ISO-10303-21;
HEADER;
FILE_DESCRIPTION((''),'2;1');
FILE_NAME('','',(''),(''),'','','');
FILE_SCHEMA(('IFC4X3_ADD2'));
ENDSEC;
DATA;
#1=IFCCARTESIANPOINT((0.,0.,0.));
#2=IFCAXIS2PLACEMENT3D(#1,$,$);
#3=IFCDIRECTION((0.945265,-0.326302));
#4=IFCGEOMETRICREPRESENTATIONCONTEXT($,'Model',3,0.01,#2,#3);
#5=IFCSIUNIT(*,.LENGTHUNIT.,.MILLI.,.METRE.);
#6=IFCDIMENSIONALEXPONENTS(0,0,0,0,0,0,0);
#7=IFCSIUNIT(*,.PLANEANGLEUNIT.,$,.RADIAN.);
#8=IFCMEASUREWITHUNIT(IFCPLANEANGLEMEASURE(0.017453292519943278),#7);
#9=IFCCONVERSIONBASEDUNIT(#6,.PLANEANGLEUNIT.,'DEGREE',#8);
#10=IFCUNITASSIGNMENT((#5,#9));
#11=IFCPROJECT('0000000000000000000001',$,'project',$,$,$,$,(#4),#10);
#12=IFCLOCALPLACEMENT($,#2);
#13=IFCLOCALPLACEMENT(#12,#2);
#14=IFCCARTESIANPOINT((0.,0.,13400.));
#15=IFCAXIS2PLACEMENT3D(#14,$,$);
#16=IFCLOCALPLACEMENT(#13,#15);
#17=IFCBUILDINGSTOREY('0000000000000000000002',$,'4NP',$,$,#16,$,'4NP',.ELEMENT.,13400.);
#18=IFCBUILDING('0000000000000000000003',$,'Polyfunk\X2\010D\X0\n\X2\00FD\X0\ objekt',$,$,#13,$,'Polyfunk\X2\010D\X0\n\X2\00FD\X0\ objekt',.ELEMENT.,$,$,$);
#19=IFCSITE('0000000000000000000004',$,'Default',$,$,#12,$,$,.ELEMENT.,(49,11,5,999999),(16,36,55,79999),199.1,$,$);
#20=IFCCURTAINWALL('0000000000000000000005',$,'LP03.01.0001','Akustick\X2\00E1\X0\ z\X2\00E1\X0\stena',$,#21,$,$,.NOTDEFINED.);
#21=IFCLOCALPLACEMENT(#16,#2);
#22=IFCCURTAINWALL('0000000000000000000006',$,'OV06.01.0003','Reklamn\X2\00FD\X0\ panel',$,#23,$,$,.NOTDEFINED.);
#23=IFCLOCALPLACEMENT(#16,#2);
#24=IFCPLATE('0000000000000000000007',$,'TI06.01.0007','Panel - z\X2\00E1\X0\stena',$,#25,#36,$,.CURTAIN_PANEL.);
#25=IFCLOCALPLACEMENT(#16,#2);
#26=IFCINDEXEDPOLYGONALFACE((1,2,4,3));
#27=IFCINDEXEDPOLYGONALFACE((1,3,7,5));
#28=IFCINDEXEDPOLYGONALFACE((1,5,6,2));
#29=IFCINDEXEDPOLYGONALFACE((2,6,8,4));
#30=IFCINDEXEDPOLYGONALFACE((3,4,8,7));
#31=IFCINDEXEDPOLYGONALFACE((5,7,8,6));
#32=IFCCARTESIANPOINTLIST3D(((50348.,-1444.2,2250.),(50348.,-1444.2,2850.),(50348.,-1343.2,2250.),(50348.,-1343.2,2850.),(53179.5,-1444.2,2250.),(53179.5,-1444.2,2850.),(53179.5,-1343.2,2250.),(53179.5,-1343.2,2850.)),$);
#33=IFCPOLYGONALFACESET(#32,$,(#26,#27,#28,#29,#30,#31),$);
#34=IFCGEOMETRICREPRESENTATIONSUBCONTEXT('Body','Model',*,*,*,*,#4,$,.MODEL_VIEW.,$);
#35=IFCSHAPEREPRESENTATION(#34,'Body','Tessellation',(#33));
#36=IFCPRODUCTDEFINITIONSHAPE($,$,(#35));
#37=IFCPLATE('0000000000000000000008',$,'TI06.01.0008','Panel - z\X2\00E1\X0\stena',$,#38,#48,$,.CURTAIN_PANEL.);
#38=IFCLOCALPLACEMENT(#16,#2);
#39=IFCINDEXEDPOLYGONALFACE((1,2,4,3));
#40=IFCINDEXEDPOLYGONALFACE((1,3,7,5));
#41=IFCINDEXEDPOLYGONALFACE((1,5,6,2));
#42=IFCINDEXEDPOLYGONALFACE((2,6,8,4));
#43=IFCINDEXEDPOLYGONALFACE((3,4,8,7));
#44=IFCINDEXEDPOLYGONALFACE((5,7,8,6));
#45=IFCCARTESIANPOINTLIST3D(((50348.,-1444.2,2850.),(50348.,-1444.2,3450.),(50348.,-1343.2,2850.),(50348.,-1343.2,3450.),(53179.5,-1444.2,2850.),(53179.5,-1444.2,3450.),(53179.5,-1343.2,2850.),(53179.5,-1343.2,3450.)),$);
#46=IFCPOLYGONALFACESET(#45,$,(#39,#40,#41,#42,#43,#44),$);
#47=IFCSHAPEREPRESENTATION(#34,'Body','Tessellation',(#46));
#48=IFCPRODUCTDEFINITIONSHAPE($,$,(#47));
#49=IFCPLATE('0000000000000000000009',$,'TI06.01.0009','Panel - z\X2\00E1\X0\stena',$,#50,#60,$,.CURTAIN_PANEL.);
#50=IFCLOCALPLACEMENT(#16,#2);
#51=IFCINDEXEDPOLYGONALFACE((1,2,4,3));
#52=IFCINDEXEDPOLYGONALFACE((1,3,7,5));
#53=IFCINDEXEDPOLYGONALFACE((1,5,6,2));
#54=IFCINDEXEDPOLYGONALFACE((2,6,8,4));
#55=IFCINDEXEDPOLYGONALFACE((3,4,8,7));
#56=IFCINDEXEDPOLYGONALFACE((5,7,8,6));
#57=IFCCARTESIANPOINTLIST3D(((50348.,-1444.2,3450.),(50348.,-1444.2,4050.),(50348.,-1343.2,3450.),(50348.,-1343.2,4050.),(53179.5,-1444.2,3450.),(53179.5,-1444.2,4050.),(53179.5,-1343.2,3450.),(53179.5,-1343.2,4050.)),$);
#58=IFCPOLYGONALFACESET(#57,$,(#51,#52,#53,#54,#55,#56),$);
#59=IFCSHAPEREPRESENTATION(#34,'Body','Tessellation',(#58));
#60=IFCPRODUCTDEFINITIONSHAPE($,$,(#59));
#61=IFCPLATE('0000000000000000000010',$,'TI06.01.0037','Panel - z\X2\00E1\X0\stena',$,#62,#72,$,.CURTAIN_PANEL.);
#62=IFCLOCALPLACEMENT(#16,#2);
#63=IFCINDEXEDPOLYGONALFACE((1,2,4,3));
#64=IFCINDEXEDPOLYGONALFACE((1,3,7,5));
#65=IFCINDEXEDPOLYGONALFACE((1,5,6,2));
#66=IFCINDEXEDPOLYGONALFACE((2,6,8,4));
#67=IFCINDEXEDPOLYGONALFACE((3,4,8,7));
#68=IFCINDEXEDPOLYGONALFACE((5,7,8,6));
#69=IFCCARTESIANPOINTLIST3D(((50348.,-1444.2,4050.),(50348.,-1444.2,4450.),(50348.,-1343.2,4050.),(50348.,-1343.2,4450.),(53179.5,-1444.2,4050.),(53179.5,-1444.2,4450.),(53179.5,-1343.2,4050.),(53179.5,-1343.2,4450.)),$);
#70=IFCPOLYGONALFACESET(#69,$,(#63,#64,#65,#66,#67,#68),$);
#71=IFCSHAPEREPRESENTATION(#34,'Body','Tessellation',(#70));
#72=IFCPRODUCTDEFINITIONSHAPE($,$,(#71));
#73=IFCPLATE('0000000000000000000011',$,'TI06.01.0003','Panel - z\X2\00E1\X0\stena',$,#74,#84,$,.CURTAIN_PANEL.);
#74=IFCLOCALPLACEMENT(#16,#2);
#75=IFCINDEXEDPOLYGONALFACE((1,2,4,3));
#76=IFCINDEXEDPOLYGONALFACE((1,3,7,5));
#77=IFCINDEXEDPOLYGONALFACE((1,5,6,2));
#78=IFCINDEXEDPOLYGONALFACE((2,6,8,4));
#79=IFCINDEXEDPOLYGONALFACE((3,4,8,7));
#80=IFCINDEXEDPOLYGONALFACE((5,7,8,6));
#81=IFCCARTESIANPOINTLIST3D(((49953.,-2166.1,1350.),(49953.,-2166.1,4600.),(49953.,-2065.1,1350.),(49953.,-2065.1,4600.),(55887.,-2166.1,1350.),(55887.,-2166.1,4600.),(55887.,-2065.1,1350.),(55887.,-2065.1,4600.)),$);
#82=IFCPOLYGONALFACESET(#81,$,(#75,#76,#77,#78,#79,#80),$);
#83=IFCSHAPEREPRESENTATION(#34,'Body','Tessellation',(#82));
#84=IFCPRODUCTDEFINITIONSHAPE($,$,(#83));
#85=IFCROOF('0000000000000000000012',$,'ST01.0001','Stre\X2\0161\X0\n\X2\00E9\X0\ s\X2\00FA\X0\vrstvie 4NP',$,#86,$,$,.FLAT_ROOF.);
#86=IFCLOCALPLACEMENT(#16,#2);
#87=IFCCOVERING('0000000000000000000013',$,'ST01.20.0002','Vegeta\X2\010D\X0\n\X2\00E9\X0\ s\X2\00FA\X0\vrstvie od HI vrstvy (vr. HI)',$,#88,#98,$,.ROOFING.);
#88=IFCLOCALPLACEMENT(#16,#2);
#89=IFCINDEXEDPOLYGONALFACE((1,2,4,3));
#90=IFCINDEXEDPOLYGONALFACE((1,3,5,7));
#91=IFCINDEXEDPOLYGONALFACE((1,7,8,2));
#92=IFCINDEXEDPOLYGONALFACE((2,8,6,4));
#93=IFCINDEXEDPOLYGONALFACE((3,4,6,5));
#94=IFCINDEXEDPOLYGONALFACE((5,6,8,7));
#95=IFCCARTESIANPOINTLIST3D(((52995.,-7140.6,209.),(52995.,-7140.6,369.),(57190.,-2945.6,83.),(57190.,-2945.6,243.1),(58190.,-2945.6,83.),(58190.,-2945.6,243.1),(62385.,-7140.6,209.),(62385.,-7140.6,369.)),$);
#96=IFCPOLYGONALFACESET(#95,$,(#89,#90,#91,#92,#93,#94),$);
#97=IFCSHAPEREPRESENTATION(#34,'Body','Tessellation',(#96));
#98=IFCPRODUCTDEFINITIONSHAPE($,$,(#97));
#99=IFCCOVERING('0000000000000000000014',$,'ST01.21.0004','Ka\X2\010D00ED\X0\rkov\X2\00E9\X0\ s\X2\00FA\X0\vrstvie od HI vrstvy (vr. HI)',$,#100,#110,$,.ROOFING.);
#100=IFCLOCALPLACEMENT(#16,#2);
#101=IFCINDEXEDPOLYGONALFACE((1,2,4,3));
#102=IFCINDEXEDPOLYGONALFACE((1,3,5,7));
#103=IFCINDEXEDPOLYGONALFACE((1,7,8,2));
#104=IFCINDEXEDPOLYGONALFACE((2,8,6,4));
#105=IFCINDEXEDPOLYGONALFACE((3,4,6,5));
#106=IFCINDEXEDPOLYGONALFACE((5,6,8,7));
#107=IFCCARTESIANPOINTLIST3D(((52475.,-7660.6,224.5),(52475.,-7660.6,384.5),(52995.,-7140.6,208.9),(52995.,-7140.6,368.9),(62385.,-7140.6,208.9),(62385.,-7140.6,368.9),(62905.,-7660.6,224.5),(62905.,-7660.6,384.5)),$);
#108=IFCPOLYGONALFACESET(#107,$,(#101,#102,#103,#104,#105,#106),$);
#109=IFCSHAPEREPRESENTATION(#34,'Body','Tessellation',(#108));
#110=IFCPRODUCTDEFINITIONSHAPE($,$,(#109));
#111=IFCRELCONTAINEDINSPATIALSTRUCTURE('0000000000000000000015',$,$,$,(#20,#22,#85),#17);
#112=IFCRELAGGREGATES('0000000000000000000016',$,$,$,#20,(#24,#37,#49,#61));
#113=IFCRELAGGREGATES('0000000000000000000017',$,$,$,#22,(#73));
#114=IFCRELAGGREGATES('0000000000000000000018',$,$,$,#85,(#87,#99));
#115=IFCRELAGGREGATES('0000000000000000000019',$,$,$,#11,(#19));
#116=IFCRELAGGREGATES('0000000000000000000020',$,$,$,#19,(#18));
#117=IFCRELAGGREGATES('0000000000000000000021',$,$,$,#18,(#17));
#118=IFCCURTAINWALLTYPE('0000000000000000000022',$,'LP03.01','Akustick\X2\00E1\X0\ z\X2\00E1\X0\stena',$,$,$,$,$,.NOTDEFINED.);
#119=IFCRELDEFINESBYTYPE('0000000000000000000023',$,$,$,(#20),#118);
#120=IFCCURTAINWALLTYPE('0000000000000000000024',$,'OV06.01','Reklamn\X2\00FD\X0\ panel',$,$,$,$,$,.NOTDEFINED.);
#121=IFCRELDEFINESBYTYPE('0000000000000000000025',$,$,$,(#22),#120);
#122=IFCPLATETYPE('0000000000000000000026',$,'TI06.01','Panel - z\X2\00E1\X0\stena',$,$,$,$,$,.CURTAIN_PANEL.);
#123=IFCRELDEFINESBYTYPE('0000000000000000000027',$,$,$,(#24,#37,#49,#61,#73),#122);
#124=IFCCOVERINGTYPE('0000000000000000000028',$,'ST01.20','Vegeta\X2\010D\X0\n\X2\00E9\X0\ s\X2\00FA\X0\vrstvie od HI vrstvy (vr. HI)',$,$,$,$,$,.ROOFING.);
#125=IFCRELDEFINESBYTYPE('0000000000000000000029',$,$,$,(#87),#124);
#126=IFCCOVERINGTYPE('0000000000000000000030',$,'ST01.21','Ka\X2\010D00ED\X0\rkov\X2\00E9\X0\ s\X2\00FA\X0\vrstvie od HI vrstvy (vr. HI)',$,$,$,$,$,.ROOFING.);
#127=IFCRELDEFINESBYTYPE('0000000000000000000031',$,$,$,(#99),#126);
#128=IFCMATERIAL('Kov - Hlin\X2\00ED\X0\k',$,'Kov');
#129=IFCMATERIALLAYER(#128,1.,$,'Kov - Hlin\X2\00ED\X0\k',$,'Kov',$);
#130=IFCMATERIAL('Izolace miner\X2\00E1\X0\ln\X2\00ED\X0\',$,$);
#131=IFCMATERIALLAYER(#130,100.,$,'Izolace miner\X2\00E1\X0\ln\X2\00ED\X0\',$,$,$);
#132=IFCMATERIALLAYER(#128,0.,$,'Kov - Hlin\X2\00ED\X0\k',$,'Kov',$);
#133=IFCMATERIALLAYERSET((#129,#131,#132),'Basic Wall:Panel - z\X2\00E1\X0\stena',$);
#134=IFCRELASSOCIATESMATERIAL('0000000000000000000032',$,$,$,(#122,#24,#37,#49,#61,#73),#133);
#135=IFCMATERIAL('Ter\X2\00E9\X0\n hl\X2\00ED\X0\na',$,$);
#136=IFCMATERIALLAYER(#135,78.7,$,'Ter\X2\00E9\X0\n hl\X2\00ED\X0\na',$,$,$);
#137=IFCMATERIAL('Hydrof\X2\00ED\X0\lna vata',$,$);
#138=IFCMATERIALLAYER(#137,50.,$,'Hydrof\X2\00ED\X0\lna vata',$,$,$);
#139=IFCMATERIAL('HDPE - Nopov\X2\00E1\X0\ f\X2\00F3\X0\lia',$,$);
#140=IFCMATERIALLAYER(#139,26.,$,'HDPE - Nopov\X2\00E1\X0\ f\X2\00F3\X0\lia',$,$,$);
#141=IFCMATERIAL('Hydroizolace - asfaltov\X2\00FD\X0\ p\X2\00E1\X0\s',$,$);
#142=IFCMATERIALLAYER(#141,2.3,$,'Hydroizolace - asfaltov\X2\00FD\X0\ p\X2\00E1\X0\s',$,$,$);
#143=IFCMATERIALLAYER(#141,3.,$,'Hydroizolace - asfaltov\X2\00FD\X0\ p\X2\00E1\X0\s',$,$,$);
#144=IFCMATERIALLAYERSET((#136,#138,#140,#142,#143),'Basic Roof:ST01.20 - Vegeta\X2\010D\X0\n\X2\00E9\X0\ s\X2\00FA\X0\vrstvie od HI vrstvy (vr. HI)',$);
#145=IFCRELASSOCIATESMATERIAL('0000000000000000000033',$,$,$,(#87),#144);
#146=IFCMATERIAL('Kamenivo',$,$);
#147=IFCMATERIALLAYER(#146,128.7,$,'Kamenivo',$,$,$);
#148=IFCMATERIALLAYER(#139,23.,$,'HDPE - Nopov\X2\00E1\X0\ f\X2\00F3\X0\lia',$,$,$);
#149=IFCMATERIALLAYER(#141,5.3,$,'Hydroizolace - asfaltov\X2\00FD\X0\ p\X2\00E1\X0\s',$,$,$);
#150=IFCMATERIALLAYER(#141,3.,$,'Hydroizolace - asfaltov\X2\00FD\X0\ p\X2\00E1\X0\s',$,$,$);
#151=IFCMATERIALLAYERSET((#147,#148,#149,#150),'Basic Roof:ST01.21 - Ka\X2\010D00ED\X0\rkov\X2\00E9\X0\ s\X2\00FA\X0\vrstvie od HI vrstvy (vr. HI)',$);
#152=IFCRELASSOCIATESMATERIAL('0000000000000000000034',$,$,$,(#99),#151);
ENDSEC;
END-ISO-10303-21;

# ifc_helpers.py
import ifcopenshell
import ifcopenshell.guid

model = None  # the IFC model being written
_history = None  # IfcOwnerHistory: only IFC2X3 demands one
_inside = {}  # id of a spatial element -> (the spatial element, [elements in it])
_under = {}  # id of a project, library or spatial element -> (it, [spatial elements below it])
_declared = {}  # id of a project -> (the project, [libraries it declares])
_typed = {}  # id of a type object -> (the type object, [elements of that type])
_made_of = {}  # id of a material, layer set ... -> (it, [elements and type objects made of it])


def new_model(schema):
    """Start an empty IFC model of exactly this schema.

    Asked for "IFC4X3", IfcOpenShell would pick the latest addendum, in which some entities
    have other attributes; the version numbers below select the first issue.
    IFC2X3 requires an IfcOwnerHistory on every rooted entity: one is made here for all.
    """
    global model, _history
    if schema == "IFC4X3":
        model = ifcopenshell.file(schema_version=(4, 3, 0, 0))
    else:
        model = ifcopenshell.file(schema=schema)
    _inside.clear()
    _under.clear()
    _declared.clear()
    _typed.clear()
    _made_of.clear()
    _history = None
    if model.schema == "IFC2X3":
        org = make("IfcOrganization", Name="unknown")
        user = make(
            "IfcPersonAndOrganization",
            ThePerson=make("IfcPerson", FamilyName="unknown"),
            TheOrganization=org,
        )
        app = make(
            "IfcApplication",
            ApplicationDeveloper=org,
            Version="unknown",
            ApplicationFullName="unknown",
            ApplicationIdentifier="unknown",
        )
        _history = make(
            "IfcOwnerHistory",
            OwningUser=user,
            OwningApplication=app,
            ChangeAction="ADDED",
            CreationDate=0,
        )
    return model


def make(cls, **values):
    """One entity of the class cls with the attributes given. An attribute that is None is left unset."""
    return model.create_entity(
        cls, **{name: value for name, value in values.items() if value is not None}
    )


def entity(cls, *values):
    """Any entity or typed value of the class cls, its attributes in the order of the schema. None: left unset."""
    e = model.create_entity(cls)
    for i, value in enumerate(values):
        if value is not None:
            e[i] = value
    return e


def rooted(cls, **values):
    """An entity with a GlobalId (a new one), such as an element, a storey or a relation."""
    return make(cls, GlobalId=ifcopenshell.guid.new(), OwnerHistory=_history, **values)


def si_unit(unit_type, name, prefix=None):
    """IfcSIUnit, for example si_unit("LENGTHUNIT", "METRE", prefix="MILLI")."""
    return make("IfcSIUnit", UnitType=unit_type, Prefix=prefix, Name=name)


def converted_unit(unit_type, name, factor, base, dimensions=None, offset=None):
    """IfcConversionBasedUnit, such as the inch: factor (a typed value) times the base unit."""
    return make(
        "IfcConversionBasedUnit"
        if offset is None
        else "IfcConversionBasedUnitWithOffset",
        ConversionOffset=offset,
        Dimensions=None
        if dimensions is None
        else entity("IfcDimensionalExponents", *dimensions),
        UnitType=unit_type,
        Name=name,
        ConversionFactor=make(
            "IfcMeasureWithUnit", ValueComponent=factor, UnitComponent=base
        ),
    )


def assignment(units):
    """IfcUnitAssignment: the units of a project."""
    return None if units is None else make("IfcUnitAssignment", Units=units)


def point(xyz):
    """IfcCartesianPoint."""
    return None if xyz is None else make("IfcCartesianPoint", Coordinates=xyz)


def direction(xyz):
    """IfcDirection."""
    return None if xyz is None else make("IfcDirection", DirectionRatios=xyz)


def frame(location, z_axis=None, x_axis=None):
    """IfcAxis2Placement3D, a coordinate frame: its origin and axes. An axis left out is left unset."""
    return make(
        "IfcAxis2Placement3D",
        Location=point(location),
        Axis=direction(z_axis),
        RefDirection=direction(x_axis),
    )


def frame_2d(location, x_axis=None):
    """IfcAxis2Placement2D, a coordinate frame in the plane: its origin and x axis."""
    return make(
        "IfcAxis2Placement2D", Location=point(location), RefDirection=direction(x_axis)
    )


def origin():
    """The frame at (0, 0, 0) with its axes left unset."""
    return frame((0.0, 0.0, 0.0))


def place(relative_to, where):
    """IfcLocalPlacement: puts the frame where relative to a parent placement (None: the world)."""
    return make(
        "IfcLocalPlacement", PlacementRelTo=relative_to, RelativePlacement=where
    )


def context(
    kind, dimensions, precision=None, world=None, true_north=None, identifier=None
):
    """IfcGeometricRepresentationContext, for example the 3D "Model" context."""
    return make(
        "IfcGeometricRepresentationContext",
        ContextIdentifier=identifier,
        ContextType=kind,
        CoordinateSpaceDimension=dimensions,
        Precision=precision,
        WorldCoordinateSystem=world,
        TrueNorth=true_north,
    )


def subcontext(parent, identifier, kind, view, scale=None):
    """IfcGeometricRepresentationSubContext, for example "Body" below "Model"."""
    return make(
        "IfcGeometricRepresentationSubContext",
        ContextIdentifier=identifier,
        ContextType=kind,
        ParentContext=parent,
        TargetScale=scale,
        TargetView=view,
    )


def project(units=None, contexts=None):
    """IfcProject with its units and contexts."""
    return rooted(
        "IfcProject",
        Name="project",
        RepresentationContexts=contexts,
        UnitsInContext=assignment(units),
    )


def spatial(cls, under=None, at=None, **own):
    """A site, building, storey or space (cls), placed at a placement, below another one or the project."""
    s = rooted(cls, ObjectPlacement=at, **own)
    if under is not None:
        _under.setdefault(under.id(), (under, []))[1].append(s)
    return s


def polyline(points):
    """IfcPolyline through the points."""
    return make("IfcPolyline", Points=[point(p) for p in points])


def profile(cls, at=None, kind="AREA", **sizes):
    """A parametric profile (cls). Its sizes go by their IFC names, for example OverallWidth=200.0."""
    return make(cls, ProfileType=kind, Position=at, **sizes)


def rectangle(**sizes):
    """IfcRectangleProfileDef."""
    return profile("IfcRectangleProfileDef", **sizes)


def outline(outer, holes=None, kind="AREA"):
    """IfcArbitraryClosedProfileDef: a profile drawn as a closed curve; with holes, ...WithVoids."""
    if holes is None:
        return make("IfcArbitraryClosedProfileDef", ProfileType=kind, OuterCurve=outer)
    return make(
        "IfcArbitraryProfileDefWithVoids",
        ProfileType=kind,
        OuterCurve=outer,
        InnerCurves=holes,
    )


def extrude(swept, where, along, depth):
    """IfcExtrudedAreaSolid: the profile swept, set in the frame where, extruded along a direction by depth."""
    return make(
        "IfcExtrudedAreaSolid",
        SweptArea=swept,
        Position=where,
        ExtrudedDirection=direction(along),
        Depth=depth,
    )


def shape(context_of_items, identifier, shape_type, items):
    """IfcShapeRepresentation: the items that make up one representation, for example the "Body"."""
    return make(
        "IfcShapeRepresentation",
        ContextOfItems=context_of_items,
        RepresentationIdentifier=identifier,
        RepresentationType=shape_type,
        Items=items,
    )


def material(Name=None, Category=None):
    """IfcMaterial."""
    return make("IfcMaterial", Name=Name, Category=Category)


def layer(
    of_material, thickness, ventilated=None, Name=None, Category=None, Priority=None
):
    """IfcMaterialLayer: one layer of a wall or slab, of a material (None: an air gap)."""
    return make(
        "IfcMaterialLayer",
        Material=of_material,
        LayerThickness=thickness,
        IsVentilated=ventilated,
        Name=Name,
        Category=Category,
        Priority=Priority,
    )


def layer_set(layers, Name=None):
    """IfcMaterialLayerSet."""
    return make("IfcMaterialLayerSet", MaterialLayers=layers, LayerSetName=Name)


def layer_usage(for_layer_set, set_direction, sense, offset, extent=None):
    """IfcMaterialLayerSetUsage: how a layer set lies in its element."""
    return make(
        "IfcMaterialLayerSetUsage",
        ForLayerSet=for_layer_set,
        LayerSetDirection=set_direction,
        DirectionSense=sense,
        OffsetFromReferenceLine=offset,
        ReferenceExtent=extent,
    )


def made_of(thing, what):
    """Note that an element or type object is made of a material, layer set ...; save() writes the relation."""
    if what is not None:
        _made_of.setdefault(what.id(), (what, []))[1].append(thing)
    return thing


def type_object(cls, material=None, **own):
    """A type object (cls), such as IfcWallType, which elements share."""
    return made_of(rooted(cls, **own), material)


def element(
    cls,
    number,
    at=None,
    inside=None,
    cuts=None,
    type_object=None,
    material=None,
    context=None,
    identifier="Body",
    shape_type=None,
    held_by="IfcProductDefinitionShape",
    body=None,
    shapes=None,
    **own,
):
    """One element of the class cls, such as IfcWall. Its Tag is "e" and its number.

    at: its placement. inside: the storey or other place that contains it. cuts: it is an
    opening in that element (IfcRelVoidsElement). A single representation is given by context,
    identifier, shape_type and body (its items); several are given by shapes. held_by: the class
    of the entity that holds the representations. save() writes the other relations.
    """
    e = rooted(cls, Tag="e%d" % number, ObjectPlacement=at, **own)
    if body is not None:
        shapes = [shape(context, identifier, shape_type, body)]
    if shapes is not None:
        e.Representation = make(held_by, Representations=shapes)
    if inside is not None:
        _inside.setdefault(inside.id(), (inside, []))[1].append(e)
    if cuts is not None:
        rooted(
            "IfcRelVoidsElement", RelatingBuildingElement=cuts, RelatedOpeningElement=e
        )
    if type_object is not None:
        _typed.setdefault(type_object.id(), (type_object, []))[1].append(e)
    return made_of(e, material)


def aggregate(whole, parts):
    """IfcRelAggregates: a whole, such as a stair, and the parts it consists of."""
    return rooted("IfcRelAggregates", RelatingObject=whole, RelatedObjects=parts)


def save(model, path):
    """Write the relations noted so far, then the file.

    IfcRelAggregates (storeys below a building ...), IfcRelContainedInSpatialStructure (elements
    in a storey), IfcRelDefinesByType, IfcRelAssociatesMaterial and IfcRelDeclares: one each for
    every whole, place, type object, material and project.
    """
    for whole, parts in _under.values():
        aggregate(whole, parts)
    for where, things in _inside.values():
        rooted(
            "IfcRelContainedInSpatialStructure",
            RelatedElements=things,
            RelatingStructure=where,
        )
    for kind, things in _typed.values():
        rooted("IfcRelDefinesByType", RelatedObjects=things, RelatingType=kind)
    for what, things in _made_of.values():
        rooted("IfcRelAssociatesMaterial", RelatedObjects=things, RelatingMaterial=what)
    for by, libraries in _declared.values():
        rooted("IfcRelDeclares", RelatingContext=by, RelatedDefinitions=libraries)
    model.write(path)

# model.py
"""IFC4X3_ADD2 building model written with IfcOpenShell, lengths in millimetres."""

from ifc_helpers import new_model, entity, si_unit, converted_unit, direction, frame, frame_2d, origin, place, context, subcontext, project, spatial, polyline, rectangle, outline, extrude, material, layer, layer_set, layer_usage, type_object, element, aggregate, save


model = new_model("IFC4X3_ADD2")

# Units and contexts
model_context = context("Model", 3, precision=0.01, world=origin(), true_north=direction((0.945265, -0.326302)))
body_context = subcontext(model_context, "Body", "Model", "MODEL_VIEW")
ifc_project = project(units=[si_unit("LENGTHUNIT", "METRE", prefix="MILLI"), converted_unit("PLANEANGLEUNIT", "DEGREE", entity("IfcPlaneAngleMeasure", 0.017453292519943278), si_unit("PLANEANGLEUNIT", "RADIAN"), dimensions=[0, 0, 0, 0, 0, 0, 0])], contexts=[model_context])

# Site, building, storey
site_placement = place(None, origin())
site = spatial("IfcSite", under=ifc_project, at=site_placement, Name="Default", CompositionType="ELEMENT", RefLatitude=(49, 11, 5, 999999), RefLongitude=(16, 36, 55, 79999), RefElevation=199.1)
building_placement = place(site_placement, origin())
building = spatial("IfcBuilding", under=site, at=building_placement, Name="Polyfunkčný objekt", LongName="Polyfunkčný objekt", CompositionType="ELEMENT")
storey_placement = place(building_placement, frame((0.0, 0.0, 13400.0)))
storey = spatial("IfcBuildingStorey", under=building, at=storey_placement, Name="4NP", LongName="4NP", CompositionType="ELEMENT", Elevation=13400.0)

# Curtain wall
curtain_wall_type_1 = type_object("IfcCurtainWallType", Name="LP03.01", Description="Akustická zástena", PredefinedType="NOTDEFINED")
curtain_wall_1_placement = place(storey_placement, frame((0.0, 0.0, -13400.0)))
curtain_wall_1 = element("IfcCurtainWall", 1, at=curtain_wall_1_placement, inside=storey, type_object=curtain_wall_type_1, Name="LP03.01.0001", Description="Akustická zástena", PredefinedType="NOTDEFINED")

# Curtain wall
curtain_wall_type_2 = type_object("IfcCurtainWallType", Name="OV06.01", Description="Reklamný panel", PredefinedType="NOTDEFINED")
curtain_wall_2_placement = place(storey_placement, frame((0.0, 0.0, -13400.0)))
curtain_wall_2 = element("IfcCurtainWall", 2, at=curtain_wall_2_placement, inside=storey, type_object=curtain_wall_type_2, Name="OV06.01.0003", Description="Reklamný panel", PredefinedType="NOTDEFINED")

# Plates
ifc_material_1 = material(Name="Kov - Hliník", Category="Kov")
ifc_layer_1 = layer(ifc_material_1, 1.0, Name="Kov - Hliník", Category="Kov")
ifc_material_2 = material(Name="Izolace minerální")
ifc_layer_2 = layer(ifc_material_2, 100.0, Name="Izolace minerální")
ifc_layer_3 = layer(ifc_material_1, 0.0, Name="Kov - Hliník", Category="Kov")
ifc_layer_set_1 = layer_set([ifc_layer_1, ifc_layer_2, ifc_layer_3], Name="Basic Wall:Panel - zástena")
plate_type = type_object("IfcPlateType", Name="TI06.01", Description="Panel - zástena", PredefinedType="CURTAIN_PANEL", material=ifc_layer_set_1)
ifc_layer_usage_1 = layer_usage(ifc_layer_set_1, "AXIS2", "POSITIVE", -50.5)
plate_1_placement = place(storey_placement, frame((50348.0, -1393.7, 2250.0)))
plate_1 = element("IfcPlate", 3, at=plate_1_placement, type_object=plate_type, material=ifc_layer_usage_1, Name="TI06.01.0007", Description="Panel - zástena", PredefinedType="CURTAIN_PANEL", context=body_context, shape_type="SweptSolid", body=[
    extrude(rectangle(XDim=101.0, YDim=2831.5, at=frame_2d((0.0, 0.0), x_axis=(1.0, 0.0))), frame((1415.8, 0.0, 0.0), z_axis=(0.0, 0.0, 1.0), x_axis=(0.0, 1.0, 0.0)), (0.0, 0.0, 1.0), 600.0),
])
ifc_layer_usage_2 = layer_usage(ifc_layer_set_1, "AXIS2", "POSITIVE", -50.5)
plate_2_placement = place(storey_placement, frame((50348.0, -1393.7, 2850.0)))
plate_2 = element("IfcPlate", 4, at=plate_2_placement, type_object=plate_type, material=ifc_layer_usage_2, Name="TI06.01.0008", Description="Panel - zástena", PredefinedType="CURTAIN_PANEL", context=body_context, shape_type="SweptSolid", body=[
    extrude(rectangle(XDim=101.0, YDim=2831.5, at=frame_2d((0.0, 0.0), x_axis=(1.0, 0.0))), frame((1415.8, 0.0, 0.0), z_axis=(0.0, 0.0, 1.0), x_axis=(0.0, 1.0, 0.0)), (0.0, 0.0, 1.0), 600.0),
])
ifc_layer_usage_3 = layer_usage(ifc_layer_set_1, "AXIS2", "POSITIVE", -50.5)
plate_3_placement = place(storey_placement, frame((50348.0, -1393.7, 3450.0)))
plate_3 = element("IfcPlate", 5, at=plate_3_placement, type_object=plate_type, material=ifc_layer_usage_3, Name="TI06.01.0009", Description="Panel - zástena", PredefinedType="CURTAIN_PANEL", context=body_context, shape_type="SweptSolid", body=[
    extrude(rectangle(XDim=101.0, YDim=2831.5, at=frame_2d((0.0, 0.0), x_axis=(1.0, 0.0))), frame((1415.8, 0.0, 0.0), z_axis=(0.0, 0.0, 1.0), x_axis=(0.0, 1.0, 0.0)), (0.0, 0.0, 1.0), 600.0),
])
ifc_layer_usage_4 = layer_usage(ifc_layer_set_1, "AXIS2", "POSITIVE", -50.5)
plate_4_placement = place(storey_placement, frame((50348.0, -1393.7, 4050.0)))
plate_4 = element("IfcPlate", 6, at=plate_4_placement, type_object=plate_type, material=ifc_layer_usage_4, Name="TI06.01.0037", Description="Panel - zástena", PredefinedType="CURTAIN_PANEL", context=body_context, shape_type="SweptSolid", body=[
    extrude(rectangle(XDim=101.0, YDim=2831.5, at=frame_2d((0.0, 0.0), x_axis=(1.0, 0.0))), frame((1415.8, 0.0, 0.0), z_axis=(0.0, 0.0, 1.0), x_axis=(0.0, 1.0, 0.0)), (0.0, 0.0, 1.0), 400.0),
])
aggregate(curtain_wall_1, [plate_1, plate_2, plate_3, plate_4])
ifc_layer_usage_5 = layer_usage(ifc_layer_set_1, "AXIS2", "NEGATIVE", 50.5)
plate_5_placement = place(storey_placement, frame((49953.0, -2115.6, 1350.0)))
plate_5 = element("IfcPlate", 7, at=plate_5_placement, type_object=plate_type, material=ifc_layer_usage_5, Name="TI06.01.0003", Description="Panel - zástena", PredefinedType="CURTAIN_PANEL", context=body_context, shape_type="SweptSolid", body=[
    extrude(rectangle(XDim=101.0, YDim=5934.0, at=frame_2d((0.0, 0.0), x_axis=(1.0, 0.0))), frame((2967.0, 0.0, 0.0), z_axis=(0.0, 0.0, 1.0), x_axis=(0.0, 1.0, 0.0)), (0.0, 0.0, 1.0), 3250.0),
])
aggregate(curtain_wall_2, [plate_5])

# Roof, coverings
roof = element("IfcRoof", 8, inside=storey, Name="ST01.0001", Description="Strešné súvrstvie 4NP", PredefinedType="FLAT_ROOF")
ifc_material_3 = material(Name="Terén hlína")
ifc_layer_4 = layer(ifc_material_3, 78.7, Name="Terén hlína")
ifc_material_4 = material(Name="Hydrofílna vata")
ifc_layer_5 = layer(ifc_material_4, 50.0, Name="Hydrofílna vata")
ifc_material_5 = material(Name="HDPE - Nopová fólia")
ifc_layer_6 = layer(ifc_material_5, 26.0, Name="HDPE - Nopová fólia")
ifc_material_6 = material(Name="Hydroizolace - asfaltový pás")
ifc_layer_7 = layer(ifc_material_6, 2.3, Name="Hydroizolace - asfaltový pás")
ifc_layer_8 = layer(ifc_material_6, 3.0, Name="Hydroizolace - asfaltový pás")
ifc_layer_set_2 = layer_set([ifc_layer_4, ifc_layer_5, ifc_layer_6, ifc_layer_7, ifc_layer_8], Name="Basic Roof:ST01.20 - Vegetačné súvrstvie od HI vrstvy (vr. HI)")
covering_type_1 = type_object("IfcCoveringType", Name="ST01.20", Description="Vegetačné súvrstvie od HI vrstvy (vr. HI)", PredefinedType="ROOFING")
placement_1 = place(storey_placement, frame((52995.0, -7140.6, 83.0)))
covering_1_placement = place(placement_1, origin())
covering_1 = element("IfcCovering", 9, at=covering_1_placement, type_object=covering_type_1, material=ifc_layer_set_2, Name="ST01.20.0002", Description="Vegetačné súvrstvie od HI vrstvy (vr. HI)", PredefinedType="ROOFING", context=body_context, shape_type="SweptSolid", body=[
    extrude(outline(polyline([(-500.0, 2098.4), (-4695.0, -2098.4), (4695.0, -2098.4), (500.0, 2098.4), (-500.0, 2098.4)])), frame((4695.0, 2097.5, 63.0), z_axis=(0.0, 0.030015, 0.999549), x_axis=(1.0, 0.0, 0.0)), (0.0, -0.030015, 0.999549), 160.1),
])
ifc_material_7 = material(Name="Kamenivo")
ifc_layer_9 = layer(ifc_material_7, 128.7, Name="Kamenivo")
ifc_layer_10 = layer(ifc_material_5, 23.0, Name="HDPE - Nopová fólia")
ifc_layer_11 = layer(ifc_material_6, 5.3, Name="Hydroizolace - asfaltový pás")
ifc_layer_12 = layer(ifc_material_6, 3.0, Name="Hydroizolace - asfaltový pás")
ifc_layer_set_3 = layer_set([ifc_layer_9, ifc_layer_10, ifc_layer_11, ifc_layer_12], Name="Basic Roof:ST01.21 - Kačírkové súvrstvie od HI vrstvy (vr. HI)")
covering_type_2 = type_object("IfcCoveringType", Name="ST01.21", Description="Kačírkové súvrstvie od HI vrstvy (vr. HI)", PredefinedType="ROOFING")
placement_2 = place(storey_placement, frame((52475.0, -7660.6, 208.9)))
covering_2_placement = place(placement_2, origin())
covering_2 = element("IfcCovering", 10, at=covering_2_placement, type_object=covering_type_2, material=ifc_layer_set_3, Name="ST01.21.0004", Description="Kačírkové súvrstvie od HI vrstvy (vr. HI)", PredefinedType="ROOFING", context=body_context, shape_type="SweptSolid", body=[
    extrude(outline(polyline([(-4695.0, 260.1), (-5215.0, -260.1), (5215.0, -260.1), (4695.0, 260.1), (-4695.0, 260.1)])), frame((5215.0, 260.0, 7.8), z_axis=(0.0, 0.030015, 0.999549), x_axis=(1.0, 0.0, 0.0)), (0.0, -0.030015, 0.999549), 160.1),
])
aggregate(roof, [covering_1, covering_2])

save(model, "model.ifc")
